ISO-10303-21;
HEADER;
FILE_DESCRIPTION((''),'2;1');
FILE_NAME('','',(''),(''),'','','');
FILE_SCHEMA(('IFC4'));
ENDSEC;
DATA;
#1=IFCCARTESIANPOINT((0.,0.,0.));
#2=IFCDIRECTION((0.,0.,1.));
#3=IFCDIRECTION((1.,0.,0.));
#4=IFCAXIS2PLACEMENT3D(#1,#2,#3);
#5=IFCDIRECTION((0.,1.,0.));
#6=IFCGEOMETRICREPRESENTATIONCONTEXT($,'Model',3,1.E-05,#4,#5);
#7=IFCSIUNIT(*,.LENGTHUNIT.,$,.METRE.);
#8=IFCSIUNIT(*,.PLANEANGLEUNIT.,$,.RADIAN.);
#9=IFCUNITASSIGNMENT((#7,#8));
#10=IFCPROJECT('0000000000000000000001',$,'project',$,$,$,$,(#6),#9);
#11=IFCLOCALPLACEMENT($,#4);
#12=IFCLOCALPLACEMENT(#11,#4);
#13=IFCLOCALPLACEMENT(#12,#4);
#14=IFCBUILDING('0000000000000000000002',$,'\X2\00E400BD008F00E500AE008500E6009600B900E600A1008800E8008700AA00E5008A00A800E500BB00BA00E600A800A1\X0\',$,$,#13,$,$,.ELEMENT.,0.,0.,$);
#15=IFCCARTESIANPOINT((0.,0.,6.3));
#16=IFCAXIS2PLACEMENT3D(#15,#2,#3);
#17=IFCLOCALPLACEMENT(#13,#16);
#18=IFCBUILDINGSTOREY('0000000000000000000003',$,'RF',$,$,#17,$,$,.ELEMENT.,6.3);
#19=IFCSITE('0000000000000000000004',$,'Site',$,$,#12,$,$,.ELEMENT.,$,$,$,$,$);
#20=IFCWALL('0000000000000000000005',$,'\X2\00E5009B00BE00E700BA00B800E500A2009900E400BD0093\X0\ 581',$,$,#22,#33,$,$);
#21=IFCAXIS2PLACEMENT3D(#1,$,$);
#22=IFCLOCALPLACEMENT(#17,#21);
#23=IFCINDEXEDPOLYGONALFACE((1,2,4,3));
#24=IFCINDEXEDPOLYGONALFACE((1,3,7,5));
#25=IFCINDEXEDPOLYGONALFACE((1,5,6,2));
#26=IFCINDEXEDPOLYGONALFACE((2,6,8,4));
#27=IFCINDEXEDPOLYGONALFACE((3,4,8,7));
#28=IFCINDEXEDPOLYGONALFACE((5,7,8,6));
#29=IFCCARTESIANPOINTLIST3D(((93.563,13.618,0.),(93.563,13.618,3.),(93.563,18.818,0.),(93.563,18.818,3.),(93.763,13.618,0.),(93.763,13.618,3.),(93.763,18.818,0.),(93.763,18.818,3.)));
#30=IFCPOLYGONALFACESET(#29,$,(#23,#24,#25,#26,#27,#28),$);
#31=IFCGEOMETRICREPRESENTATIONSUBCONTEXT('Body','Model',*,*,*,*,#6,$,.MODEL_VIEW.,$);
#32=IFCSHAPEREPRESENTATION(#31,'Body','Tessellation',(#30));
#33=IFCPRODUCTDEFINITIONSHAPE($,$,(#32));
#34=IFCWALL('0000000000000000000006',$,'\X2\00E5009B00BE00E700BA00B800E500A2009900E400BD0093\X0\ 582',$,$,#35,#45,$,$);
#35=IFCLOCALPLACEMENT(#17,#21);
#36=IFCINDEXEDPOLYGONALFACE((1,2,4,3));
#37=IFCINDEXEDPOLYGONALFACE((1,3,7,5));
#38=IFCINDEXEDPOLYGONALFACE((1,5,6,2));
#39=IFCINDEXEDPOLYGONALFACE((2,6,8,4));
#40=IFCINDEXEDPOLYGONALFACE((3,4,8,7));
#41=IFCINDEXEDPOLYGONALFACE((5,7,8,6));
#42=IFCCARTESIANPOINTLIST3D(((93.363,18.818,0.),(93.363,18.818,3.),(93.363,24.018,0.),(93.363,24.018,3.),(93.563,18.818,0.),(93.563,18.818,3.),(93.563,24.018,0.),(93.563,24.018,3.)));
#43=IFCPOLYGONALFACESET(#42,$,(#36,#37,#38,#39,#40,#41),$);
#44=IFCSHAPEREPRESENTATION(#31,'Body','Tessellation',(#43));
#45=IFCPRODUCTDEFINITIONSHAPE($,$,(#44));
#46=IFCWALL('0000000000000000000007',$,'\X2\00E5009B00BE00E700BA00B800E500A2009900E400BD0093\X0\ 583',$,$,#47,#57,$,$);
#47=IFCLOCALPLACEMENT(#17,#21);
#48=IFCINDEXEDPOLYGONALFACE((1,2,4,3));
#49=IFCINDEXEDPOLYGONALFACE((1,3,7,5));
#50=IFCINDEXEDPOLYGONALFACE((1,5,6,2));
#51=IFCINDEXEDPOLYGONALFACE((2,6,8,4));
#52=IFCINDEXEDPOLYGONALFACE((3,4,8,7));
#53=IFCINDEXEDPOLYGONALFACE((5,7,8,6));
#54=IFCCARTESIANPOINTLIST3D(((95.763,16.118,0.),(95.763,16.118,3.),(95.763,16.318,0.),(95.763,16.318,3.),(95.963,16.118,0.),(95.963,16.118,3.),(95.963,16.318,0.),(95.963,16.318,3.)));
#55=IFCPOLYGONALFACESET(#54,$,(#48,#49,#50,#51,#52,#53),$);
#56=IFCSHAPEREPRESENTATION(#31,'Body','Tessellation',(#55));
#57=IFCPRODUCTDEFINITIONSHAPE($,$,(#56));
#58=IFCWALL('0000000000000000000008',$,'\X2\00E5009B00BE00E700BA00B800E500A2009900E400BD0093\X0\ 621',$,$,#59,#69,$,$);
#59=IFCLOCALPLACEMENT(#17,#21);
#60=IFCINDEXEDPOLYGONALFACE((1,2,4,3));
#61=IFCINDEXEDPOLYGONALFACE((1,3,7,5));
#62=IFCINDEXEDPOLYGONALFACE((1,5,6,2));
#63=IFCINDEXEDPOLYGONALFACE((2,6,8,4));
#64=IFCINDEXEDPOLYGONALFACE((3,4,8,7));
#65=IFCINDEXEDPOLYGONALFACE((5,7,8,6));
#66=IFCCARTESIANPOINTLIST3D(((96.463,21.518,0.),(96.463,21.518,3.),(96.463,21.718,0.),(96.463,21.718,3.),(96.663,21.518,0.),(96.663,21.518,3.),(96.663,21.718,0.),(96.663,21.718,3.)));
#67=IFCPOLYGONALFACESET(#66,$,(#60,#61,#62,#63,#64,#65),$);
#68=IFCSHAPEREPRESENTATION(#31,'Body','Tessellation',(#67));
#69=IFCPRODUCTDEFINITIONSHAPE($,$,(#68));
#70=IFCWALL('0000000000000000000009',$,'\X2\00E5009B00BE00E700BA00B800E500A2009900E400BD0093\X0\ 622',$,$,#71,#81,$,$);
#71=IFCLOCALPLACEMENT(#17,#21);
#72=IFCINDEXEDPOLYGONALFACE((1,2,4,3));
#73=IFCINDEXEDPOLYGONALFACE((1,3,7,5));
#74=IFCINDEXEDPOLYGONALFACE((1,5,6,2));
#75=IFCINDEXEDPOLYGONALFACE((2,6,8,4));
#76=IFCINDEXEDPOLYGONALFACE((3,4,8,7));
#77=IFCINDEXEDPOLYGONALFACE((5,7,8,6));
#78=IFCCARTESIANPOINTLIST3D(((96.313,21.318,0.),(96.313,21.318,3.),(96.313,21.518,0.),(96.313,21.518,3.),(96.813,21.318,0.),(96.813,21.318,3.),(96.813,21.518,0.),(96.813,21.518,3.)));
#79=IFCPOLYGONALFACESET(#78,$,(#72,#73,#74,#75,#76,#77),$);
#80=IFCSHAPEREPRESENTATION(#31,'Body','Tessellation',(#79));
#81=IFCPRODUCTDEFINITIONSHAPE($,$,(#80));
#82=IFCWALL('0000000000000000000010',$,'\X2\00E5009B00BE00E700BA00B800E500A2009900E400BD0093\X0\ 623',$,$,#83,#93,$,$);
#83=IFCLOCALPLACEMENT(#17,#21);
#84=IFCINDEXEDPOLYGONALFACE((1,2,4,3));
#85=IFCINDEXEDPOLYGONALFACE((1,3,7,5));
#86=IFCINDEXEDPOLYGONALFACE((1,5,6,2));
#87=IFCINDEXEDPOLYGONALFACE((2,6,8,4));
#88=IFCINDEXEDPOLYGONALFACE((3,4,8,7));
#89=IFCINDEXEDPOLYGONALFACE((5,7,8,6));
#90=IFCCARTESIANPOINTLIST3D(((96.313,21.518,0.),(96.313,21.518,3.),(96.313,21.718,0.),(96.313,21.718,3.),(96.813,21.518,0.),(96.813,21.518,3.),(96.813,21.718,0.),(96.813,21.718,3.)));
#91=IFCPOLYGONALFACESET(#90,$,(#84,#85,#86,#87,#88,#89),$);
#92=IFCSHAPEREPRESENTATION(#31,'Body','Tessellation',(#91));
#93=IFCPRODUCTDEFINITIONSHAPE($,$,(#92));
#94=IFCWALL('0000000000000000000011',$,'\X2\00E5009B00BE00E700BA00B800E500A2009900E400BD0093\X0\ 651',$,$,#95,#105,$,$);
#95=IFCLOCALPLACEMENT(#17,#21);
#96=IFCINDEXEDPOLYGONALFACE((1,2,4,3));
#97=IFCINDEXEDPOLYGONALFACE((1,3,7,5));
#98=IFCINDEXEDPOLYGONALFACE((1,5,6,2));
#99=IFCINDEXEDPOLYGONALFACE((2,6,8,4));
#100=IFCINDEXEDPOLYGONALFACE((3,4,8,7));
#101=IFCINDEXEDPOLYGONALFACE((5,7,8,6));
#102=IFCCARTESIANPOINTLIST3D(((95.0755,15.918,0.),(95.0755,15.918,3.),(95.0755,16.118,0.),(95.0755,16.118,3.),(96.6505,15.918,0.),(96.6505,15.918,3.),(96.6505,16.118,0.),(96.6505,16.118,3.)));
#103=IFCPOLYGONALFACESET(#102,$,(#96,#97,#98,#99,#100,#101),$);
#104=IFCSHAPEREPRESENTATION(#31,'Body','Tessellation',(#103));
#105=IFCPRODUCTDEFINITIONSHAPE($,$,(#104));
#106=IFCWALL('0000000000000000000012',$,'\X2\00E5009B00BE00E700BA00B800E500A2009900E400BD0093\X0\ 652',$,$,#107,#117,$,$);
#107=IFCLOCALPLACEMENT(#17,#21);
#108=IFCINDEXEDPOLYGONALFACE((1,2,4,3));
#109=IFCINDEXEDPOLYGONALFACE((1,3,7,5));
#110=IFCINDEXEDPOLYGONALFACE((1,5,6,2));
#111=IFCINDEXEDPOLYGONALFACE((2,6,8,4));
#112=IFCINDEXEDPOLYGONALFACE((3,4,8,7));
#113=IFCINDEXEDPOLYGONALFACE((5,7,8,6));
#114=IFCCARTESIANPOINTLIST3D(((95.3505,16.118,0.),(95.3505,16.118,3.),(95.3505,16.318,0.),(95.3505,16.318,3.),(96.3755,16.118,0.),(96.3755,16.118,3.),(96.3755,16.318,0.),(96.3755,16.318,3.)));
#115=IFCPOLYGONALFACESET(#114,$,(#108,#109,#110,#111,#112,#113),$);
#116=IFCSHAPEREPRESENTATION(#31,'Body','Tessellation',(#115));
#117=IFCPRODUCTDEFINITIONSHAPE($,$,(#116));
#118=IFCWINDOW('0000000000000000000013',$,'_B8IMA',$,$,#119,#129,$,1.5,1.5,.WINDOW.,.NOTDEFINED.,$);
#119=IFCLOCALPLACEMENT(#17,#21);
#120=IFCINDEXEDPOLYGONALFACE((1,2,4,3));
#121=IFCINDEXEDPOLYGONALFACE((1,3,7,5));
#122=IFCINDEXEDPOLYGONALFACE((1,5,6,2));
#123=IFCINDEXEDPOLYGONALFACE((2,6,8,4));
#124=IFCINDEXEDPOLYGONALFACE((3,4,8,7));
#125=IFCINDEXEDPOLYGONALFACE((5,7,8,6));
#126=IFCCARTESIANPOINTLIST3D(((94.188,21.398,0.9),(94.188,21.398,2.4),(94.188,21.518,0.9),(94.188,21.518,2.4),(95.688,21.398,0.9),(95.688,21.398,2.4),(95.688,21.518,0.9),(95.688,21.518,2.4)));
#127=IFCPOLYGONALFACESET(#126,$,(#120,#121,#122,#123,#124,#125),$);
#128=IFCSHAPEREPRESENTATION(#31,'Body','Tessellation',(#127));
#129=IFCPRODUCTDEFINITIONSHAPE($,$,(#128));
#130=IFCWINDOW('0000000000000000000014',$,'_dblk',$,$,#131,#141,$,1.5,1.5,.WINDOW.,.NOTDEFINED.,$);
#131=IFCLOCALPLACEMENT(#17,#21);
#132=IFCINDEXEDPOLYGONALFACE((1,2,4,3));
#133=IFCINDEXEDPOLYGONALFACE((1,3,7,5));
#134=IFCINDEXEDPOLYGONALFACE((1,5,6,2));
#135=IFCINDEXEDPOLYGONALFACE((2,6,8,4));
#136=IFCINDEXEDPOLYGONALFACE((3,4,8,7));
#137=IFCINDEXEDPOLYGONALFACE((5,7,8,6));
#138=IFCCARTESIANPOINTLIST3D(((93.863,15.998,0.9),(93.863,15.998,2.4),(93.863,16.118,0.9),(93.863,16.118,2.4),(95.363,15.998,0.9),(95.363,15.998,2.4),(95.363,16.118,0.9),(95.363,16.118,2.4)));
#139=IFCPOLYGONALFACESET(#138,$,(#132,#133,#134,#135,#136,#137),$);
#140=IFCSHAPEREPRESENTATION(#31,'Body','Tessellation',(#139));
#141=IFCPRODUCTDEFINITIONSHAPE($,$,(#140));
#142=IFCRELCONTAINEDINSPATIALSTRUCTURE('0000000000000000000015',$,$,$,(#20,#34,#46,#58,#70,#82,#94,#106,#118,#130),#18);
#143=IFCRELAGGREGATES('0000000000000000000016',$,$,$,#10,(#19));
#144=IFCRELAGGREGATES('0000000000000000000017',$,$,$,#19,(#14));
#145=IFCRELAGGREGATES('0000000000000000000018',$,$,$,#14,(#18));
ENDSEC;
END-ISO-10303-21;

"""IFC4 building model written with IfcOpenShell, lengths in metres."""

from ifc_helpers import new_model, si_unit, direction, frame, frame_2d, origin_with_axes, place, context, subcontext, project, spatial, rectangle, extrude, element, save


model = new_model("IFC4")

# Units and contexts
model_context = context("Model", 3, precision=1e-05, world=origin_with_axes(), true_north=direction((0.0, 1.0, 0.0)))
body_context = subcontext(model_context, "Body", "Model", "MODEL_VIEW")
ifc_project = project(units=[si_unit("LENGTHUNIT", "METRE"), si_unit("PLANEANGLEUNIT", "RADIAN")], contexts=[model_context])

# Site, building, storey
placement = place(None, origin_with_axes())
site_placement = place(placement, origin_with_axes())
site = spatial("IfcSite", under=ifc_project, at=site_placement, Name="Site", CompositionType="ELEMENT")
building_placement = place(site_placement, origin_with_axes())
building = spatial("IfcBuilding", under=site, at=building_placement, Name="ä½\u008få®\u0085æ\u0096¹æ¡\u0088è\u0087ªå\u008a¨å»ºæ¨¡", CompositionType="ELEMENT", ElevationOfRefHeight=0.0, ElevationOfTerrain=0.0)
storey_placement = place(building_placement, frame((0.0, 0.0, 6.3), z_axis=(0.0, 0.0, 1.0), x_axis=(1.0, 0.0, 0.0)))
storey = spatial("IfcBuildingStorey", under=building, at=storey_placement, Name="RF", CompositionType="ELEMENT", Elevation=6.3)

# Walls
for number, where, z_axis, x_axis, name in (
    (1, (93.663, 16.218, 0.0), (0.0, 0.0, 1.0), (0.0, 1.0, 0.0), "å\u009b¾çº¸å¢\u0099ä½\u0093 581"),
    (2, (93.463, 21.418, 0.0), (0.0, 0.0, 1.0), (0.0, -1.0, 0.0), "å\u009b¾çº¸å¢\u0099ä½\u0093 582"),
):
    element("IfcWall", number, at=place(storey_placement, frame(where, z_axis=z_axis, x_axis=x_axis)), inside=storey, Name=name, context=body_context, shape_type="SweptSolid", body=[
        extrude(rectangle(XDim=5.2, YDim=0.2, at=frame_2d((0.0, 0.0), x_axis=(1.0, 0.0, 0.0))), frame((0.0, 0.0, 0.0), z_axis=(0.0, 0.0, 1.0)), (0.0, 0.0, 1.0), 3.0),
    ])
for number, where, z_axis, x_axis, name in (
    (3, (95.863, 16.218, 0.0), (0.0, 0.0, 1.0), (0.0, -1.0, 0.0), "å\u009b¾çº¸å¢\u0099ä½\u0093 583"),
    (4, (96.563, 21.618, 0.0), (0.0, 0.0, 1.0), (0.0, -1.0, 0.0), "å\u009b¾çº¸å¢\u0099ä½\u0093 621"),
):
    element("IfcWall", number, at=place(storey_placement, frame(where, z_axis=z_axis, x_axis=x_axis)), inside=storey, Name=name, context=body_context, shape_type="SweptSolid", body=[
        extrude(rectangle(XDim=0.2, YDim=0.2, at=frame_2d((0.0, 0.0), x_axis=(1.0, 0.0, 0.0))), frame((0.0, 0.0, 0.0), z_axis=(0.0, 0.0, 1.0)), (0.0, 0.0, 1.0), 3.0),
    ])
for number, where, z_axis, x_axis, name in (
    (5, (96.563, 21.418, 0.0), (0.0, 0.0, 1.0), (1.0, 0.0, 0.0), "å\u009b¾çº¸å¢\u0099ä½\u0093 622"),
    (6, (96.563, 21.618, 0.0), (0.0, 0.0, 1.0), (1.0, 0.0, 0.0), "å\u009b¾çº¸å¢\u0099ä½\u0093 623"),
):
    element("IfcWall", number, at=place(storey_placement, frame(where, z_axis=z_axis, x_axis=x_axis)), inside=storey, Name=name, context=body_context, shape_type="SweptSolid", body=[
        extrude(rectangle(XDim=0.5, YDim=0.2, at=frame_2d((0.0, 0.0), x_axis=(1.0, 0.0, 0.0))), frame((0.0, 0.0, 0.0), z_axis=(0.0, 0.0, 1.0)), (0.0, 0.0, 1.0), 3.0),
    ])
wall_1_placement = place(storey_placement, frame((95.863, 16.018, 0.0), z_axis=(0.0, 0.0, 1.0), x_axis=(1.0, 0.0, 0.0)))
element("IfcWall", 7, at=wall_1_placement, inside=storey, Name="å\u009b¾çº¸å¢\u0099ä½\u0093 651", context=body_context, shape_type="SweptSolid", body=[
    extrude(rectangle(XDim=1.575, YDim=0.2, at=frame_2d((0.0, 0.0), x_axis=(1.0, 0.0, 0.0))), frame((0.0, 0.0, 0.0), z_axis=(0.0, 0.0, 1.0)), (0.0, 0.0, 1.0), 3.0),
])
wall_2_placement = place(storey_placement, frame((95.863, 16.218, 0.0), z_axis=(0.0, 0.0, 1.0), x_axis=(1.0, 0.0, 0.0)))
element("IfcWall", 8, at=wall_2_placement, inside=storey, Name="å\u009b¾çº¸å¢\u0099ä½\u0093 652", context=body_context, shape_type="SweptSolid", body=[
    extrude(rectangle(XDim=1.025, YDim=0.2, at=frame_2d((0.0, 0.0), x_axis=(1.0, 0.0, 0.0))), frame((0.0, 0.0, 0.0), z_axis=(0.0, 0.0, 1.0)), (0.0, 0.0, 1.0), 3.0),
])

# Windows
for number, where, z_axis, x_axis, name in (
    (9, (94.938, 21.458, 0.9), (0.0, 0.0, 1.0), (1.0, 0.0, 0.0), "_B8IMA"),
    (10, (94.613, 16.058, 0.9), (0.0, 0.0, 1.0), (1.0, 0.0, 0.0), "_dblk"),
):
    element("IfcWindow", number, at=place(storey_placement, frame(where, z_axis=z_axis, x_axis=x_axis)), inside=storey, Name=name, OverallHeight=1.5, OverallWidth=1.5, PartitioningType="NOTDEFINED", PredefinedType="WINDOW", context=body_context, shape_type="SweptSolid", body=[
        extrude(rectangle(XDim=1.5, YDim=0.12, at=frame_2d((0.0, 0.0), x_axis=(1.0, 0.0, 0.0))), frame((0.0, 0.0, 0.0), z_axis=(0.0, 0.0, 1.0)), (0.0, 0.0, 1.0), 1.5),
    ])

save(model, "model.ifc")
